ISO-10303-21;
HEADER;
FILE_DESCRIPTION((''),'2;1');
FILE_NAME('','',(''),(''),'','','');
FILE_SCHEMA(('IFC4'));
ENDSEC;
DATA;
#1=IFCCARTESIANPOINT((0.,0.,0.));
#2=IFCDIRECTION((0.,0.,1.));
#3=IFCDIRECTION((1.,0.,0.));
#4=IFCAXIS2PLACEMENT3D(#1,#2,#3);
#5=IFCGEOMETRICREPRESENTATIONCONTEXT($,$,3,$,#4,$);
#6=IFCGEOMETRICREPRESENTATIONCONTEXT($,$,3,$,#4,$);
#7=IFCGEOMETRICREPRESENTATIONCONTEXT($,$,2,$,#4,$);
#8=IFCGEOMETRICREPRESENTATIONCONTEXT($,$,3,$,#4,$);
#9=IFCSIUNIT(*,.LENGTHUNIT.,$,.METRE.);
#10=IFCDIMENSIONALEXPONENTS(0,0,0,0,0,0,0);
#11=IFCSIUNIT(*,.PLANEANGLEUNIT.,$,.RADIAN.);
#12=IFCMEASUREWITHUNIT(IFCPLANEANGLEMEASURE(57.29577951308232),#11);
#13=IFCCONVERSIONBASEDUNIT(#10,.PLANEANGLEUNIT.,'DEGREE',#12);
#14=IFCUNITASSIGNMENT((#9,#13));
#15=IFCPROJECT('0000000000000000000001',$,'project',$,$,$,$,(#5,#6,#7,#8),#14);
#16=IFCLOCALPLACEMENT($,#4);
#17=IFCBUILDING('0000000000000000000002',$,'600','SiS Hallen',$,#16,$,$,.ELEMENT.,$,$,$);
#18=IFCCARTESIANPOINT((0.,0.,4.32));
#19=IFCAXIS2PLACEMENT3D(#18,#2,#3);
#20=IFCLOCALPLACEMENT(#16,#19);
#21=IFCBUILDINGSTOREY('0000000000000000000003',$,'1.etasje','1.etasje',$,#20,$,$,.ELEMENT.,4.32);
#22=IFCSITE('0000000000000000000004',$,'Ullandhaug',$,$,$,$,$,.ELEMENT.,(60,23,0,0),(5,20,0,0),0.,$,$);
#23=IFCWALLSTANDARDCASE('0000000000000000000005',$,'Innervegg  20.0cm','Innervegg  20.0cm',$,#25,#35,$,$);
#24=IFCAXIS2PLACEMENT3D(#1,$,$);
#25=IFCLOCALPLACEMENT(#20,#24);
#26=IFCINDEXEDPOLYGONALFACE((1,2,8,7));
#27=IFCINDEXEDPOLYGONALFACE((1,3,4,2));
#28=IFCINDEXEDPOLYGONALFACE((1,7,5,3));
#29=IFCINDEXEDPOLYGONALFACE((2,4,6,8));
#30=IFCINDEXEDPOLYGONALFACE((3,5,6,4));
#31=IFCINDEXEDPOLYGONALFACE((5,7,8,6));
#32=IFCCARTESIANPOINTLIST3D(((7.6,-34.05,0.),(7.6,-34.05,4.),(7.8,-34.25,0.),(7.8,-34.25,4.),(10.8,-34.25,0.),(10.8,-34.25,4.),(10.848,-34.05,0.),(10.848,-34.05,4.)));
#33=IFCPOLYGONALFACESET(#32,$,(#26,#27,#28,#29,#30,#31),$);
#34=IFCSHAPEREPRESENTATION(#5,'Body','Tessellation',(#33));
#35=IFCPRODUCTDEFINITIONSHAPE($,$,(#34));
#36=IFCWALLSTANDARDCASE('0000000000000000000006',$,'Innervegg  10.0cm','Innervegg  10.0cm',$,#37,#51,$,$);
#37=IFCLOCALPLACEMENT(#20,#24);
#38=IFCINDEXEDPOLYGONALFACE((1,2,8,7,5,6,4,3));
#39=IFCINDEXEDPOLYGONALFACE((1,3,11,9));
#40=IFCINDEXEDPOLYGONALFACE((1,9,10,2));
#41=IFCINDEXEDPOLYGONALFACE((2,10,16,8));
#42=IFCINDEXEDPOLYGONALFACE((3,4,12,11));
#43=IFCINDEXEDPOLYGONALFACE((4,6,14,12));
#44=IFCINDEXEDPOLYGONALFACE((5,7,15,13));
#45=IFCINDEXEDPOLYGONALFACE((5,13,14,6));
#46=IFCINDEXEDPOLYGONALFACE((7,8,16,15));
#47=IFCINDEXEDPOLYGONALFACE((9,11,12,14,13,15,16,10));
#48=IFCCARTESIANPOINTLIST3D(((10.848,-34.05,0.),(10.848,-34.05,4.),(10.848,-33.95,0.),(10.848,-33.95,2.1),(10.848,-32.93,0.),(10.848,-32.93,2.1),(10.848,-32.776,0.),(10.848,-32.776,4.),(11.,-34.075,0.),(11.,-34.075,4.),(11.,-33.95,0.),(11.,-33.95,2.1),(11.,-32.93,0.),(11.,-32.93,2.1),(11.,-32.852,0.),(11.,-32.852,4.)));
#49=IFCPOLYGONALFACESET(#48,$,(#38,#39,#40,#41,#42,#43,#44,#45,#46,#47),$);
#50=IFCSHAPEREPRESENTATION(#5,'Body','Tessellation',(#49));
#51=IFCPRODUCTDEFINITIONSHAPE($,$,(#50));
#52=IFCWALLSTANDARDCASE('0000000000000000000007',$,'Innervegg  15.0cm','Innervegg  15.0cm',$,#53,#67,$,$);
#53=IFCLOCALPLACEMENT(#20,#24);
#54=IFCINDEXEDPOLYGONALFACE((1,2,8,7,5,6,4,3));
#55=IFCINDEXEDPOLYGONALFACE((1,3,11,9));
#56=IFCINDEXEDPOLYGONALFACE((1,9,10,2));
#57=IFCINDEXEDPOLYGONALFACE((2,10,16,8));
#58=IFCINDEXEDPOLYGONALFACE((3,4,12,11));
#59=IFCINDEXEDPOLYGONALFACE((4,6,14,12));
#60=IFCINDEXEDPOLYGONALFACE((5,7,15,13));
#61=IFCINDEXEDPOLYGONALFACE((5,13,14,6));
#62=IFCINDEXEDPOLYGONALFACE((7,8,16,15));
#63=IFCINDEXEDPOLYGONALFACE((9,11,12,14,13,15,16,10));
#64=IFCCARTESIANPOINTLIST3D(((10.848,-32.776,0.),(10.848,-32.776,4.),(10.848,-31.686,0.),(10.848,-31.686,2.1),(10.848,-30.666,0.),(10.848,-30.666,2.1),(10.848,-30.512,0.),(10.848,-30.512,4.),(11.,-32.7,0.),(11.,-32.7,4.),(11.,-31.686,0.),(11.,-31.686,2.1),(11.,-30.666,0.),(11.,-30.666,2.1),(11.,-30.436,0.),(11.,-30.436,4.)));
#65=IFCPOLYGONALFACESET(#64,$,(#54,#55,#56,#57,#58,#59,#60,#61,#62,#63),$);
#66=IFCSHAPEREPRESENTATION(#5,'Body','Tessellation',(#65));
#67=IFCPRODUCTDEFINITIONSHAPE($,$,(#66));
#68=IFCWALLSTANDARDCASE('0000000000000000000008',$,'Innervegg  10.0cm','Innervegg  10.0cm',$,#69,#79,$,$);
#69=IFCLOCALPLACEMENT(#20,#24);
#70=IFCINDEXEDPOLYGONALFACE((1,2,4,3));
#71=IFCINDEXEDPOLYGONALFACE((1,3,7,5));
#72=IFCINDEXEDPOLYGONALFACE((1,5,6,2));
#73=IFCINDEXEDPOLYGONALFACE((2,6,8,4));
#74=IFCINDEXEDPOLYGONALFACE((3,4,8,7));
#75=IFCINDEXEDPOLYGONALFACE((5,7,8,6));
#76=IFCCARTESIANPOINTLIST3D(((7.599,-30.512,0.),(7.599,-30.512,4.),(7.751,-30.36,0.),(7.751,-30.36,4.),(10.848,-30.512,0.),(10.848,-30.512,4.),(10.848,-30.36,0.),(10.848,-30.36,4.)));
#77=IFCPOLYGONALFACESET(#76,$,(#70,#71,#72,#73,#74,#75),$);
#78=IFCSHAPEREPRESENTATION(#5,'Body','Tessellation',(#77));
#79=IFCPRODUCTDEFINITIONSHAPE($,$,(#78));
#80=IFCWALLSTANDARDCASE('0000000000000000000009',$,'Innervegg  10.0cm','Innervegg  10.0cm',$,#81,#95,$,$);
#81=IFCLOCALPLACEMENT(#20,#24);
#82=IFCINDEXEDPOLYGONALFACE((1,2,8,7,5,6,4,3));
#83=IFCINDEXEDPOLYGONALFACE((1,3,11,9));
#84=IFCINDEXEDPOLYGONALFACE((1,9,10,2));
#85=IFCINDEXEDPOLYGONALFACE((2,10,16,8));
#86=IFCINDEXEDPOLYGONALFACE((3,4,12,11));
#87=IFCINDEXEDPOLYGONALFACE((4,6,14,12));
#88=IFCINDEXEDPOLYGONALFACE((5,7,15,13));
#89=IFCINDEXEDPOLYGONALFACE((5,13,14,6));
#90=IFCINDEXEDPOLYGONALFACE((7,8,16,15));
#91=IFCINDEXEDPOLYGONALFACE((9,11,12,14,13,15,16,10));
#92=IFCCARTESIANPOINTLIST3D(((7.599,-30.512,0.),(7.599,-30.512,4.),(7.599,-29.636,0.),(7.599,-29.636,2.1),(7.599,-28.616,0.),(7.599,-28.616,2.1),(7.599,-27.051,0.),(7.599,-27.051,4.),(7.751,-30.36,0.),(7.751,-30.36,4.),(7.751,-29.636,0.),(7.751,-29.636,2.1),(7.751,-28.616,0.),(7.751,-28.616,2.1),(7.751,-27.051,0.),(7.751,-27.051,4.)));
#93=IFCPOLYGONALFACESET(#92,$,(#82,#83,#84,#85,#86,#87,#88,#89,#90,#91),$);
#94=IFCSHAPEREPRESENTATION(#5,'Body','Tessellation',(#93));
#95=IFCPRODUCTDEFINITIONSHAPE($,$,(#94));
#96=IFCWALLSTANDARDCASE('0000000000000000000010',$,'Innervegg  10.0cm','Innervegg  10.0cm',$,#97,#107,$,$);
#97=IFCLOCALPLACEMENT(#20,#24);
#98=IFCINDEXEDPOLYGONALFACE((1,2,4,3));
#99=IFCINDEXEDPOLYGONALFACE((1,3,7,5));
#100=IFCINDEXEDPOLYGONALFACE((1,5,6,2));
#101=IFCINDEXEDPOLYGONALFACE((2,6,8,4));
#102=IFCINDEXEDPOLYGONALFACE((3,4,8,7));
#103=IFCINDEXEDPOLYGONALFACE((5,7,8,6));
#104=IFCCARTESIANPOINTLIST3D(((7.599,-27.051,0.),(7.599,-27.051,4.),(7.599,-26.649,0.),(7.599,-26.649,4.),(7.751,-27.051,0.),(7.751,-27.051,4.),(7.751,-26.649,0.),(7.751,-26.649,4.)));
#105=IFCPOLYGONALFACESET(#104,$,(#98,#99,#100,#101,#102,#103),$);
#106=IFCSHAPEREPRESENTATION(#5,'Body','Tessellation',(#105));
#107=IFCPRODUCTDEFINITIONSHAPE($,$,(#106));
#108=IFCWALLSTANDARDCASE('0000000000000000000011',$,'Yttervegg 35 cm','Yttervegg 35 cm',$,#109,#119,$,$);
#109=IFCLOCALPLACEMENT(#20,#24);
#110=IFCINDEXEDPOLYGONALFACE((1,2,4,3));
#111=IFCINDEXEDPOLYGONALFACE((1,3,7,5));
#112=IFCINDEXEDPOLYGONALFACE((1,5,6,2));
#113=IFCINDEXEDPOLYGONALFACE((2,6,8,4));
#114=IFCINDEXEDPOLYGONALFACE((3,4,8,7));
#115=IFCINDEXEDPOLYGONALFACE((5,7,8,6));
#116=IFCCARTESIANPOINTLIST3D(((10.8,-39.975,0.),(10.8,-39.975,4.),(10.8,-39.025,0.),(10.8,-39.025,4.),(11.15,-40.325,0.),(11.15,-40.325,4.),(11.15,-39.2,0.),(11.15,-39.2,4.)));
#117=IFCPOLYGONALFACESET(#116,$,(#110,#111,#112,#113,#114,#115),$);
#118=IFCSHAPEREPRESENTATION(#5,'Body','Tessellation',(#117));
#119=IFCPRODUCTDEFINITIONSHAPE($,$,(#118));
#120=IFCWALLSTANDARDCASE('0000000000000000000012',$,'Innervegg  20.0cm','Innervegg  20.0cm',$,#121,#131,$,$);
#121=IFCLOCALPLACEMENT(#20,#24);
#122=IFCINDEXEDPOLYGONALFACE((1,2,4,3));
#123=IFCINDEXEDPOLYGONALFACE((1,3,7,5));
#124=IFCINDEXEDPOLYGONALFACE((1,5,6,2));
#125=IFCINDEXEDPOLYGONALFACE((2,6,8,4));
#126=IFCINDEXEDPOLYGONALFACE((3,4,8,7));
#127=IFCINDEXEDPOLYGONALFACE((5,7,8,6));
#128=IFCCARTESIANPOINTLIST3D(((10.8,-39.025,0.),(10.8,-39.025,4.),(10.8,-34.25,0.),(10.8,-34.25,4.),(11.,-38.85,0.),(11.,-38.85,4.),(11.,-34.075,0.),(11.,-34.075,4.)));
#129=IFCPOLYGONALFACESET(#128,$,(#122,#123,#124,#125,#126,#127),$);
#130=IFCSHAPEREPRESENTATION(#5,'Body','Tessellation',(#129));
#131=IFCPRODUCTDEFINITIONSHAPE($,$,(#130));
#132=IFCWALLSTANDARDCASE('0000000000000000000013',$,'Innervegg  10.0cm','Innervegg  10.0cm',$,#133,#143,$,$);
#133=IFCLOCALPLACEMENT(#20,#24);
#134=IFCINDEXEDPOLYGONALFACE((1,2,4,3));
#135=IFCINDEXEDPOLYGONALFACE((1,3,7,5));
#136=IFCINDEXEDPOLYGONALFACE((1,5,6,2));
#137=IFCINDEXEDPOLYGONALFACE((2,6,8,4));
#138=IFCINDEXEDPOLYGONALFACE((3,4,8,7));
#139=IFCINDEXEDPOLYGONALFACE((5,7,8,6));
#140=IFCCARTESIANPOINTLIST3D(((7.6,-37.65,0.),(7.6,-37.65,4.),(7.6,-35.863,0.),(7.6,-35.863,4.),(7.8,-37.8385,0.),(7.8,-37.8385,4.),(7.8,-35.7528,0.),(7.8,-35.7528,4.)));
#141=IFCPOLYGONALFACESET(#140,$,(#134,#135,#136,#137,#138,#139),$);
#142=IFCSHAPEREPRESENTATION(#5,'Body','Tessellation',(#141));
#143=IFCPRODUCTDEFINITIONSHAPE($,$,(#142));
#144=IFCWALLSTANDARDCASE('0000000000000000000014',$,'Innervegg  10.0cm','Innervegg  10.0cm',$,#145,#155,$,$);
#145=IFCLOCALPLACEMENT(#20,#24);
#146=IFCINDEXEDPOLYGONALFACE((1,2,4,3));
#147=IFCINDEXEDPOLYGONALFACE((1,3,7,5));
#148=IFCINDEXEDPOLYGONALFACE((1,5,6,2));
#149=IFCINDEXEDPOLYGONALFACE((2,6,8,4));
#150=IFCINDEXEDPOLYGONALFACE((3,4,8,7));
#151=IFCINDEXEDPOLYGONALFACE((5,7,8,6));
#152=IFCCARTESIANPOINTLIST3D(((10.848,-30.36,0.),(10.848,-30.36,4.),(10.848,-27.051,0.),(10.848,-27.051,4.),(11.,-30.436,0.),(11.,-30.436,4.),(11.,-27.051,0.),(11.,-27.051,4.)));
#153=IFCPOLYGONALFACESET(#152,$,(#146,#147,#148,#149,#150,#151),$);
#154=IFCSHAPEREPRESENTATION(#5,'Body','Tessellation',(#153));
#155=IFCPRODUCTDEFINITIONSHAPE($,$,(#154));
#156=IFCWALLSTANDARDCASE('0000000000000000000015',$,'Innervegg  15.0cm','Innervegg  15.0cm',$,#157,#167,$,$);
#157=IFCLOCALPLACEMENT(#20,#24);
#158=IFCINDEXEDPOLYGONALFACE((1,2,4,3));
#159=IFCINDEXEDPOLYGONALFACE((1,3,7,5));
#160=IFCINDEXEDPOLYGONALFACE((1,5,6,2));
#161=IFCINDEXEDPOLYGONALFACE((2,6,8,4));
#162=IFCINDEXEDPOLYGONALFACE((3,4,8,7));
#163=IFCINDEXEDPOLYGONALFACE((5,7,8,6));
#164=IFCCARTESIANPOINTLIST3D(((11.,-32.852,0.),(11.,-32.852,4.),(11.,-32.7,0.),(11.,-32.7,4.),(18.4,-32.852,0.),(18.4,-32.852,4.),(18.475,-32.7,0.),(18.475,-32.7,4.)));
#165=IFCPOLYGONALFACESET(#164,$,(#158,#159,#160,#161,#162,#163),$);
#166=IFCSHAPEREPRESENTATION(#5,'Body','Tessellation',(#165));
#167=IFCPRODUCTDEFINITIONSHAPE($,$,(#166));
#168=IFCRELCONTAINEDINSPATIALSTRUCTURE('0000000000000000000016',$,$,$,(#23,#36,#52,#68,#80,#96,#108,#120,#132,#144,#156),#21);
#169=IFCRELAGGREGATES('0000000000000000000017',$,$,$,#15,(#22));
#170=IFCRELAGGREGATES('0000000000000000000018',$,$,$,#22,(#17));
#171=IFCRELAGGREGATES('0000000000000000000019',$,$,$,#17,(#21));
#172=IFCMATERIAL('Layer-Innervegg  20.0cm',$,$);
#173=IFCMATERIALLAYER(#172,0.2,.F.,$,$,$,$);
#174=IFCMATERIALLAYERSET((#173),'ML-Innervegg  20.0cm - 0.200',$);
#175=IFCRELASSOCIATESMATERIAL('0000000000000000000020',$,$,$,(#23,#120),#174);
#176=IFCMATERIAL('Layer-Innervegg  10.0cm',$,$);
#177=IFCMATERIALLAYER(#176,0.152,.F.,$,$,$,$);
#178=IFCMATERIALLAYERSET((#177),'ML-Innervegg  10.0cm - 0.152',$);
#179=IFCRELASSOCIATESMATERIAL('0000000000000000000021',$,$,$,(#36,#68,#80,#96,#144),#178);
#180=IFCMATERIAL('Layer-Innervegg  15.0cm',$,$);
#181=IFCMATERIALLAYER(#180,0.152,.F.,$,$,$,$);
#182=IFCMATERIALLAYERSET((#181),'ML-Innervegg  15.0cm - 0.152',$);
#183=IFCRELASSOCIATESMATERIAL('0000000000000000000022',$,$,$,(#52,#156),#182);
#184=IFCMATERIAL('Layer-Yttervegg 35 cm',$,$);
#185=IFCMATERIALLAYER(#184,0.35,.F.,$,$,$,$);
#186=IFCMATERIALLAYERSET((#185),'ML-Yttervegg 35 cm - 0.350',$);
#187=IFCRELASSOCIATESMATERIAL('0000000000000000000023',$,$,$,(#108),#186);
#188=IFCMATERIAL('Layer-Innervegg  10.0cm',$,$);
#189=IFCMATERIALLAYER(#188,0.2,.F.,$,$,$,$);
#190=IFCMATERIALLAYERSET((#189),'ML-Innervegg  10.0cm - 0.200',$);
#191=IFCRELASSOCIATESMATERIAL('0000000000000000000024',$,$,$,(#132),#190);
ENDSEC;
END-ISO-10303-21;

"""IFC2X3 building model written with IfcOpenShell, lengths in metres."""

from ifc_helpers import new_model, entity, si_unit, converted_unit, frame, origin_with_axes, place, context, project, spatial, polyline, outline, extrude, material, layer, layer_set, layer_usage, element, save


model = new_model("IFC2X3")

# Units and contexts
context_of_model_1 = context(None, 3, world=origin_with_axes())
context_of_model_2 = context(None, 3, world=origin_with_axes())
context_of_model_3 = context(None, 2, world=origin_with_axes())
context_of_model_4 = context(None, 3, world=origin_with_axes())
ifc_project = project(units=[si_unit("LENGTHUNIT", "METRE"), converted_unit("PLANEANGLEUNIT", "DEGREE", entity("IfcPlaneAngleMeasure", 57.29577951308232), si_unit("PLANEANGLEUNIT", "RADIAN"), dimensions=[0, 0, 0, 0, 0, 0, 0])], contexts=[context_of_model_1, context_of_model_2, context_of_model_3, context_of_model_4])

# Site, building, storey
site = spatial("IfcSite", under=ifc_project, Name="Ullandhaug", CompositionType="ELEMENT", RefLatitude=(60, 23, 0, 0), RefLongitude=(5, 20, 0, 0), RefElevation=0.0)
building_placement = place(None, origin_with_axes())
building = spatial("IfcBuilding", under=site, at=building_placement, Name="600", Description="SiS Hallen", CompositionType="ELEMENT")
storey_placement = place(building_placement, frame((0.0, 0.0, 4.32), z_axis=(0.0, 0.0, 1.0), x_axis=(1.0, 0.0, 0.0)))
storey = spatial("IfcBuildingStorey", under=building, at=storey_placement, Name="1.etasje", Description="1.etasje", CompositionType="ELEMENT", Elevation=4.32)

# Shared definitions
ifc_material_1 = material(Name="Layer-Innervegg  20.0cm")
ifc_layer_1 = layer(ifc_material_1, 0.2, ventilated=False)
ifc_layer_set_1 = layer_set([ifc_layer_1], Name="ML-Innervegg  20.0cm - 0.200")
ifc_layer_usage_1 = layer_usage(ifc_layer_set_1, "AXIS2", "POSITIVE", 0.0)

# Shared definitions
ifc_material_2 = material(Name="Layer-Innervegg  10.0cm")
ifc_layer_2 = layer(ifc_material_2, 0.2, ventilated=False)
ifc_layer_set_2 = layer_set([ifc_layer_2], Name="ML-Innervegg  10.0cm - 0.200")
ifc_layer_usage_2 = layer_usage(ifc_layer_set_2, "AXIS2", "POSITIVE", 0.0)

# Wall
wall_1_placement = place(storey_placement, frame((7.8, -34.25, 0.0), z_axis=(0.0, 0.0, 1.0), x_axis=(1.0, 0.0, 0.0)))
element("IfcWallStandardCase", 1, at=wall_1_placement, inside=storey, material=ifc_layer_usage_1, Name="Innervegg  20.0cm", Description="Innervegg  20.0cm", context=context_of_model_1, shape_type="SweptSolid", body=[
    extrude(outline(polyline([(0.0, 0.0), (3.0, 0.0), (3.048, 0.2), (-0.2, 0.2), (0.0, 0.0)])), origin_with_axes(), (0.0, 0.0, 1.0), 4.0),
])

# Walls, openings
ifc_material_3 = material(Name="Layer-Innervegg  10.0cm")
ifc_layer_3 = layer(ifc_material_3, 0.152, ventilated=False)
ifc_layer_set_3 = layer_set([ifc_layer_3], Name="ML-Innervegg  10.0cm - 0.152")
ifc_layer_usage_3 = layer_usage(ifc_layer_set_3, "AXIS2", "POSITIVE", 0.0)
wall_2_placement = place(storey_placement, frame((11.0, -34.075, 0.0), z_axis=(0.0, 0.0, 1.0), x_axis=(0.0, 1.0, 0.0)))
wall_2 = element("IfcWallStandardCase", 2, at=wall_2_placement, inside=storey, material=ifc_layer_usage_3, Name="Innervegg  10.0cm", Description="Innervegg  10.0cm", context=context_of_model_1, shape_type="SweptSolid", body=[
    extrude(outline(polyline([(0.0, 0.0), (1.223, 0.0), (1.299, 0.152), (0.025, 0.152), (0.0, 0.0)])), frame((0.0, 0.0, 0.0), z_axis=(0.0, 0.0, 1.0), x_axis=(1.0, 0.0, 0.0)), (0.0, 0.0, 1.0), 4.0),
])
opening_1_placement = place(wall_2_placement, frame((0.125, 0.152, 0.0), z_axis=(0.0, 0.0, 1.0), x_axis=(1.0, 0.0, 0.0)))
element("IfcOpeningElement", 3, at=opening_1_placement, cuts=wall_2, context=context_of_model_1, shape_type="SweptSolid", body=[
    extrude(outline(polyline([(0.0, 0.0), (2.1, 0.0), (2.1, 1.02), (0.0, 1.02), (0.0, 0.0)])), frame((0.0, 0.0, 0.0), z_axis=(0.0, 1.0, 0.0), x_axis=(0.0, 0.0, 1.0)), (0.0, 0.0, -1.0), 0.152),
])
ifc_material_4 = material(Name="Layer-Innervegg  15.0cm")
ifc_layer_4 = layer(ifc_material_4, 0.152, ventilated=False)
ifc_layer_set_4 = layer_set([ifc_layer_4], Name="ML-Innervegg  15.0cm - 0.152")
ifc_layer_usage_4 = layer_usage(ifc_layer_set_4, "AXIS2", "POSITIVE", 0.0)
wall_3_placement = place(storey_placement, frame((11.0, -32.7, 0.0), z_axis=(0.0, 0.0, 1.0), x_axis=(0.0, 1.0, 0.0)))
wall_3 = element("IfcWallStandardCase", 4, at=wall_3_placement, inside=storey, material=ifc_layer_usage_4, Name="Innervegg  15.0cm", Description="Innervegg  15.0cm", context=context_of_model_1, shape_type="SweptSolid", body=[
    extrude(outline(polyline([(0.0, 0.0), (2.264, 0.0), (2.188, 0.152), (-0.076, 0.152), (0.0, 0.0)])), frame((0.0, 0.0, 0.0), z_axis=(0.0, 0.0, 1.0), x_axis=(1.0, 0.0, 0.0)), (0.0, 0.0, 1.0), 4.0),
])
opening_2_placement = place(wall_3_placement, frame((1.014, 0.152, 0.0), z_axis=(0.0, 0.0, 1.0), x_axis=(1.0, 0.0, 0.0)))
element("IfcOpeningElement", 5, at=opening_2_placement, cuts=wall_3, context=context_of_model_1, shape_type="SweptSolid", body=[
    extrude(outline(polyline([(0.0, 0.0), (2.1, 0.0), (2.1, 1.02), (0.0, 1.02), (0.0, 0.0)])), frame((0.0, 0.0, 0.0), z_axis=(0.0, 1.0, 0.0), x_axis=(0.0, 0.0, 1.0)), (0.0, 0.0, -1.0), 0.152),
])

# Wall
wall_4_placement = place(storey_placement, frame((10.848, -30.36, 0.0), z_axis=(0.0, 0.0, 1.0), x_axis=(-1.0, 0.0, 0.0)))
element("IfcWallStandardCase", 6, at=wall_4_placement, inside=storey, material=ifc_layer_usage_3, Name="Innervegg  10.0cm", Description="Innervegg  10.0cm", context=context_of_model_1, shape_type="SweptSolid", body=[
    extrude(outline(polyline([(0.0, 0.0), (3.097, 0.0), (3.249, 0.152), (0.0, 0.152), (0.0, 0.0)])), frame((0.0, 0.0, 0.0), z_axis=(0.0, 0.0, 1.0), x_axis=(1.0, 0.0, 0.0)), (0.0, 0.0, 1.0), 4.0),
])

# Wall, opening
wall_5_placement = place(storey_placement, frame((7.751, -30.36, 0.0), z_axis=(0.0, 0.0, 1.0), x_axis=(0.0, 1.0, 0.0)))
wall_5 = element("IfcWallStandardCase", 7, at=wall_5_placement, inside=storey, material=ifc_layer_usage_3, Name="Innervegg  10.0cm", Description="Innervegg  10.0cm", context=context_of_model_1, shape_type="SweptSolid", body=[
    extrude(outline(polyline([(0.0, 0.0), (3.309, 0.0), (3.309, 0.152), (-0.152, 0.152), (0.0, 0.0)])), frame((0.0, 0.0, 0.0), z_axis=(0.0, 0.0, 1.0), x_axis=(1.0, 0.0, 0.0)), (0.0, 0.0, 1.0), 4.0),
])
opening_3_placement = place(wall_5_placement, frame((0.724, 0.152, 0.0), z_axis=(0.0, 0.0, 1.0), x_axis=(1.0, 0.0, 0.0)))
element("IfcOpeningElement", 8, at=opening_3_placement, cuts=wall_5, context=context_of_model_1, shape_type="SweptSolid", body=[
    extrude(outline(polyline([(0.0, 0.0), (2.1, 0.0), (2.1, 1.02), (0.0, 1.02), (0.0, 0.0)])), frame((0.0, 0.0, 0.0), z_axis=(0.0, 1.0, 0.0), x_axis=(0.0, 0.0, 1.0)), (0.0, 0.0, -1.0), 0.152),
])

# Walls
wall_6_placement = place(storey_placement, frame((7.751, -27.051, 0.0), z_axis=(0.0, 0.0, 1.0), x_axis=(0.0, 1.0, 0.0)))
element("IfcWallStandardCase", 9, at=wall_6_placement, inside=storey, material=ifc_layer_usage_3, Name="Innervegg  10.0cm", Description="Innervegg  10.0cm", context=context_of_model_1, shape_type="SweptSolid", body=[
    extrude(outline(polyline([(0.0, 0.0), (0.402, 0.0), (0.402, 0.152), (0.0, 0.152), (0.0, 0.0)])), frame((0.0, 0.0, 0.0), z_axis=(0.0, 0.0, 1.0), x_axis=(1.0, 0.0, 0.0)), (0.0, 0.0, 1.0), 4.0),
])
ifc_material_5 = material(Name="Layer-Yttervegg 35 cm")
ifc_layer_5 = layer(ifc_material_5, 0.35, ventilated=False)
ifc_layer_set_5 = layer_set([ifc_layer_5], Name="ML-Yttervegg 35 cm - 0.350")
ifc_layer_usage_5 = layer_usage(ifc_layer_set_5, "AXIS2", "POSITIVE", 0.0)
wall_7_placement = place(storey_placement, frame((11.15, -40.325, 0.0), z_axis=(0.0, 0.0, 1.0), x_axis=(0.0, 1.0, 0.0)))
element("IfcWallStandardCase", 10, at=wall_7_placement, inside=storey, material=ifc_layer_usage_5, Name="Yttervegg 35 cm", Description="Yttervegg 35 cm", context=context_of_model_1, shape_type="SweptSolid", body=[
    extrude(outline(polyline([(0.0, 0.0), (1.125, 0.0), (1.3, 0.35), (0.35, 0.35), (0.0, 0.0)])), frame((0.0, 0.0, 0.0), z_axis=(0.0, 0.0, 1.0), x_axis=(1.0, 0.0, 0.0)), (0.0, 0.0, 1.0), 4.0),
])
wall_8_placement = place(storey_placement, frame((11.0, -38.85, 0.0), z_axis=(0.0, 0.0, 1.0), x_axis=(0.0, 1.0, 0.0)))
element("IfcWallStandardCase", 11, at=wall_8_placement, inside=storey, material=ifc_layer_usage_1, Name="Innervegg  20.0cm", Description="Innervegg  20.0cm", context=context_of_model_1, shape_type="SweptSolid", body=[
    extrude(outline(polyline([(0.0, 0.0), (4.775, 0.0), (4.6, 0.2), (-0.175, 0.2), (0.0, 0.0)])), frame((0.0, 0.0, 0.0), z_axis=(0.0, 0.0, 1.0), x_axis=(1.0, 0.0, 0.0)), (0.0, 0.0, 1.0), 4.0),
])
wall_9_placement = place(storey_placement, frame((7.6, -35.863, 0.0), z_axis=(0.0, 0.0, 1.0), x_axis=(0.0, -1.0, 0.0)))
element("IfcWallStandardCase", 12, at=wall_9_placement, inside=storey, material=ifc_layer_usage_2, Name="Innervegg  10.0cm", Description="Innervegg  10.0cm", context=context_of_model_1, shape_type="SweptSolid", body=[
    extrude(outline(polyline([(0.0, 0.0), (1.787, 0.0), (1.9755, 0.2), (-0.1103, 0.2), (0.0, 0.0)])), frame((0.0, 0.0, 0.0), z_axis=(0.0, 0.0, 1.0), x_axis=(1.0, 0.0, 0.0)), (0.0, 0.0, 1.0), 4.0),
])
wall_10_placement = place(storey_placement, frame((11.0, -30.436, 0.0), z_axis=(0.0, 0.0, 1.0), x_axis=(0.0, 1.0, 0.0)))
element("IfcWallStandardCase", 13, at=wall_10_placement, inside=storey, material=ifc_layer_usage_3, Name="Innervegg  10.0cm", Description="Innervegg  10.0cm", context=context_of_model_1, shape_type="SweptSolid", body=[
    extrude(outline(polyline([(0.0, 0.0), (3.385, 0.0), (3.385, 0.152), (0.076, 0.152), (0.0, 0.0)])), frame((0.0, 0.0, 0.0), z_axis=(0.0, 0.0, 1.0), x_axis=(1.0, 0.0, 0.0)), (0.0, 0.0, 1.0), 4.0),
])
wall_11_placement = place(storey_placement, frame((11.0, -32.852, 0.0), z_axis=(0.0, 0.0, 1.0), x_axis=(1.0, 0.0, 0.0)))
element("IfcWallStandardCase", 14, at=wall_11_placement, inside=storey, material=ifc_layer_usage_4, Name="Innervegg  15.0cm", Description="Innervegg  15.0cm", context=context_of_model_1, shape_type="SweptSolid", body=[
    extrude(outline(polyline([(0.0, 0.0), (7.4, 0.0), (7.475, 0.152), (0.0, 0.152), (0.0, 0.0)])), origin_with_axes(), (0.0, 0.0, 1.0), 4.0),
])

save(model, "model.ifc")
